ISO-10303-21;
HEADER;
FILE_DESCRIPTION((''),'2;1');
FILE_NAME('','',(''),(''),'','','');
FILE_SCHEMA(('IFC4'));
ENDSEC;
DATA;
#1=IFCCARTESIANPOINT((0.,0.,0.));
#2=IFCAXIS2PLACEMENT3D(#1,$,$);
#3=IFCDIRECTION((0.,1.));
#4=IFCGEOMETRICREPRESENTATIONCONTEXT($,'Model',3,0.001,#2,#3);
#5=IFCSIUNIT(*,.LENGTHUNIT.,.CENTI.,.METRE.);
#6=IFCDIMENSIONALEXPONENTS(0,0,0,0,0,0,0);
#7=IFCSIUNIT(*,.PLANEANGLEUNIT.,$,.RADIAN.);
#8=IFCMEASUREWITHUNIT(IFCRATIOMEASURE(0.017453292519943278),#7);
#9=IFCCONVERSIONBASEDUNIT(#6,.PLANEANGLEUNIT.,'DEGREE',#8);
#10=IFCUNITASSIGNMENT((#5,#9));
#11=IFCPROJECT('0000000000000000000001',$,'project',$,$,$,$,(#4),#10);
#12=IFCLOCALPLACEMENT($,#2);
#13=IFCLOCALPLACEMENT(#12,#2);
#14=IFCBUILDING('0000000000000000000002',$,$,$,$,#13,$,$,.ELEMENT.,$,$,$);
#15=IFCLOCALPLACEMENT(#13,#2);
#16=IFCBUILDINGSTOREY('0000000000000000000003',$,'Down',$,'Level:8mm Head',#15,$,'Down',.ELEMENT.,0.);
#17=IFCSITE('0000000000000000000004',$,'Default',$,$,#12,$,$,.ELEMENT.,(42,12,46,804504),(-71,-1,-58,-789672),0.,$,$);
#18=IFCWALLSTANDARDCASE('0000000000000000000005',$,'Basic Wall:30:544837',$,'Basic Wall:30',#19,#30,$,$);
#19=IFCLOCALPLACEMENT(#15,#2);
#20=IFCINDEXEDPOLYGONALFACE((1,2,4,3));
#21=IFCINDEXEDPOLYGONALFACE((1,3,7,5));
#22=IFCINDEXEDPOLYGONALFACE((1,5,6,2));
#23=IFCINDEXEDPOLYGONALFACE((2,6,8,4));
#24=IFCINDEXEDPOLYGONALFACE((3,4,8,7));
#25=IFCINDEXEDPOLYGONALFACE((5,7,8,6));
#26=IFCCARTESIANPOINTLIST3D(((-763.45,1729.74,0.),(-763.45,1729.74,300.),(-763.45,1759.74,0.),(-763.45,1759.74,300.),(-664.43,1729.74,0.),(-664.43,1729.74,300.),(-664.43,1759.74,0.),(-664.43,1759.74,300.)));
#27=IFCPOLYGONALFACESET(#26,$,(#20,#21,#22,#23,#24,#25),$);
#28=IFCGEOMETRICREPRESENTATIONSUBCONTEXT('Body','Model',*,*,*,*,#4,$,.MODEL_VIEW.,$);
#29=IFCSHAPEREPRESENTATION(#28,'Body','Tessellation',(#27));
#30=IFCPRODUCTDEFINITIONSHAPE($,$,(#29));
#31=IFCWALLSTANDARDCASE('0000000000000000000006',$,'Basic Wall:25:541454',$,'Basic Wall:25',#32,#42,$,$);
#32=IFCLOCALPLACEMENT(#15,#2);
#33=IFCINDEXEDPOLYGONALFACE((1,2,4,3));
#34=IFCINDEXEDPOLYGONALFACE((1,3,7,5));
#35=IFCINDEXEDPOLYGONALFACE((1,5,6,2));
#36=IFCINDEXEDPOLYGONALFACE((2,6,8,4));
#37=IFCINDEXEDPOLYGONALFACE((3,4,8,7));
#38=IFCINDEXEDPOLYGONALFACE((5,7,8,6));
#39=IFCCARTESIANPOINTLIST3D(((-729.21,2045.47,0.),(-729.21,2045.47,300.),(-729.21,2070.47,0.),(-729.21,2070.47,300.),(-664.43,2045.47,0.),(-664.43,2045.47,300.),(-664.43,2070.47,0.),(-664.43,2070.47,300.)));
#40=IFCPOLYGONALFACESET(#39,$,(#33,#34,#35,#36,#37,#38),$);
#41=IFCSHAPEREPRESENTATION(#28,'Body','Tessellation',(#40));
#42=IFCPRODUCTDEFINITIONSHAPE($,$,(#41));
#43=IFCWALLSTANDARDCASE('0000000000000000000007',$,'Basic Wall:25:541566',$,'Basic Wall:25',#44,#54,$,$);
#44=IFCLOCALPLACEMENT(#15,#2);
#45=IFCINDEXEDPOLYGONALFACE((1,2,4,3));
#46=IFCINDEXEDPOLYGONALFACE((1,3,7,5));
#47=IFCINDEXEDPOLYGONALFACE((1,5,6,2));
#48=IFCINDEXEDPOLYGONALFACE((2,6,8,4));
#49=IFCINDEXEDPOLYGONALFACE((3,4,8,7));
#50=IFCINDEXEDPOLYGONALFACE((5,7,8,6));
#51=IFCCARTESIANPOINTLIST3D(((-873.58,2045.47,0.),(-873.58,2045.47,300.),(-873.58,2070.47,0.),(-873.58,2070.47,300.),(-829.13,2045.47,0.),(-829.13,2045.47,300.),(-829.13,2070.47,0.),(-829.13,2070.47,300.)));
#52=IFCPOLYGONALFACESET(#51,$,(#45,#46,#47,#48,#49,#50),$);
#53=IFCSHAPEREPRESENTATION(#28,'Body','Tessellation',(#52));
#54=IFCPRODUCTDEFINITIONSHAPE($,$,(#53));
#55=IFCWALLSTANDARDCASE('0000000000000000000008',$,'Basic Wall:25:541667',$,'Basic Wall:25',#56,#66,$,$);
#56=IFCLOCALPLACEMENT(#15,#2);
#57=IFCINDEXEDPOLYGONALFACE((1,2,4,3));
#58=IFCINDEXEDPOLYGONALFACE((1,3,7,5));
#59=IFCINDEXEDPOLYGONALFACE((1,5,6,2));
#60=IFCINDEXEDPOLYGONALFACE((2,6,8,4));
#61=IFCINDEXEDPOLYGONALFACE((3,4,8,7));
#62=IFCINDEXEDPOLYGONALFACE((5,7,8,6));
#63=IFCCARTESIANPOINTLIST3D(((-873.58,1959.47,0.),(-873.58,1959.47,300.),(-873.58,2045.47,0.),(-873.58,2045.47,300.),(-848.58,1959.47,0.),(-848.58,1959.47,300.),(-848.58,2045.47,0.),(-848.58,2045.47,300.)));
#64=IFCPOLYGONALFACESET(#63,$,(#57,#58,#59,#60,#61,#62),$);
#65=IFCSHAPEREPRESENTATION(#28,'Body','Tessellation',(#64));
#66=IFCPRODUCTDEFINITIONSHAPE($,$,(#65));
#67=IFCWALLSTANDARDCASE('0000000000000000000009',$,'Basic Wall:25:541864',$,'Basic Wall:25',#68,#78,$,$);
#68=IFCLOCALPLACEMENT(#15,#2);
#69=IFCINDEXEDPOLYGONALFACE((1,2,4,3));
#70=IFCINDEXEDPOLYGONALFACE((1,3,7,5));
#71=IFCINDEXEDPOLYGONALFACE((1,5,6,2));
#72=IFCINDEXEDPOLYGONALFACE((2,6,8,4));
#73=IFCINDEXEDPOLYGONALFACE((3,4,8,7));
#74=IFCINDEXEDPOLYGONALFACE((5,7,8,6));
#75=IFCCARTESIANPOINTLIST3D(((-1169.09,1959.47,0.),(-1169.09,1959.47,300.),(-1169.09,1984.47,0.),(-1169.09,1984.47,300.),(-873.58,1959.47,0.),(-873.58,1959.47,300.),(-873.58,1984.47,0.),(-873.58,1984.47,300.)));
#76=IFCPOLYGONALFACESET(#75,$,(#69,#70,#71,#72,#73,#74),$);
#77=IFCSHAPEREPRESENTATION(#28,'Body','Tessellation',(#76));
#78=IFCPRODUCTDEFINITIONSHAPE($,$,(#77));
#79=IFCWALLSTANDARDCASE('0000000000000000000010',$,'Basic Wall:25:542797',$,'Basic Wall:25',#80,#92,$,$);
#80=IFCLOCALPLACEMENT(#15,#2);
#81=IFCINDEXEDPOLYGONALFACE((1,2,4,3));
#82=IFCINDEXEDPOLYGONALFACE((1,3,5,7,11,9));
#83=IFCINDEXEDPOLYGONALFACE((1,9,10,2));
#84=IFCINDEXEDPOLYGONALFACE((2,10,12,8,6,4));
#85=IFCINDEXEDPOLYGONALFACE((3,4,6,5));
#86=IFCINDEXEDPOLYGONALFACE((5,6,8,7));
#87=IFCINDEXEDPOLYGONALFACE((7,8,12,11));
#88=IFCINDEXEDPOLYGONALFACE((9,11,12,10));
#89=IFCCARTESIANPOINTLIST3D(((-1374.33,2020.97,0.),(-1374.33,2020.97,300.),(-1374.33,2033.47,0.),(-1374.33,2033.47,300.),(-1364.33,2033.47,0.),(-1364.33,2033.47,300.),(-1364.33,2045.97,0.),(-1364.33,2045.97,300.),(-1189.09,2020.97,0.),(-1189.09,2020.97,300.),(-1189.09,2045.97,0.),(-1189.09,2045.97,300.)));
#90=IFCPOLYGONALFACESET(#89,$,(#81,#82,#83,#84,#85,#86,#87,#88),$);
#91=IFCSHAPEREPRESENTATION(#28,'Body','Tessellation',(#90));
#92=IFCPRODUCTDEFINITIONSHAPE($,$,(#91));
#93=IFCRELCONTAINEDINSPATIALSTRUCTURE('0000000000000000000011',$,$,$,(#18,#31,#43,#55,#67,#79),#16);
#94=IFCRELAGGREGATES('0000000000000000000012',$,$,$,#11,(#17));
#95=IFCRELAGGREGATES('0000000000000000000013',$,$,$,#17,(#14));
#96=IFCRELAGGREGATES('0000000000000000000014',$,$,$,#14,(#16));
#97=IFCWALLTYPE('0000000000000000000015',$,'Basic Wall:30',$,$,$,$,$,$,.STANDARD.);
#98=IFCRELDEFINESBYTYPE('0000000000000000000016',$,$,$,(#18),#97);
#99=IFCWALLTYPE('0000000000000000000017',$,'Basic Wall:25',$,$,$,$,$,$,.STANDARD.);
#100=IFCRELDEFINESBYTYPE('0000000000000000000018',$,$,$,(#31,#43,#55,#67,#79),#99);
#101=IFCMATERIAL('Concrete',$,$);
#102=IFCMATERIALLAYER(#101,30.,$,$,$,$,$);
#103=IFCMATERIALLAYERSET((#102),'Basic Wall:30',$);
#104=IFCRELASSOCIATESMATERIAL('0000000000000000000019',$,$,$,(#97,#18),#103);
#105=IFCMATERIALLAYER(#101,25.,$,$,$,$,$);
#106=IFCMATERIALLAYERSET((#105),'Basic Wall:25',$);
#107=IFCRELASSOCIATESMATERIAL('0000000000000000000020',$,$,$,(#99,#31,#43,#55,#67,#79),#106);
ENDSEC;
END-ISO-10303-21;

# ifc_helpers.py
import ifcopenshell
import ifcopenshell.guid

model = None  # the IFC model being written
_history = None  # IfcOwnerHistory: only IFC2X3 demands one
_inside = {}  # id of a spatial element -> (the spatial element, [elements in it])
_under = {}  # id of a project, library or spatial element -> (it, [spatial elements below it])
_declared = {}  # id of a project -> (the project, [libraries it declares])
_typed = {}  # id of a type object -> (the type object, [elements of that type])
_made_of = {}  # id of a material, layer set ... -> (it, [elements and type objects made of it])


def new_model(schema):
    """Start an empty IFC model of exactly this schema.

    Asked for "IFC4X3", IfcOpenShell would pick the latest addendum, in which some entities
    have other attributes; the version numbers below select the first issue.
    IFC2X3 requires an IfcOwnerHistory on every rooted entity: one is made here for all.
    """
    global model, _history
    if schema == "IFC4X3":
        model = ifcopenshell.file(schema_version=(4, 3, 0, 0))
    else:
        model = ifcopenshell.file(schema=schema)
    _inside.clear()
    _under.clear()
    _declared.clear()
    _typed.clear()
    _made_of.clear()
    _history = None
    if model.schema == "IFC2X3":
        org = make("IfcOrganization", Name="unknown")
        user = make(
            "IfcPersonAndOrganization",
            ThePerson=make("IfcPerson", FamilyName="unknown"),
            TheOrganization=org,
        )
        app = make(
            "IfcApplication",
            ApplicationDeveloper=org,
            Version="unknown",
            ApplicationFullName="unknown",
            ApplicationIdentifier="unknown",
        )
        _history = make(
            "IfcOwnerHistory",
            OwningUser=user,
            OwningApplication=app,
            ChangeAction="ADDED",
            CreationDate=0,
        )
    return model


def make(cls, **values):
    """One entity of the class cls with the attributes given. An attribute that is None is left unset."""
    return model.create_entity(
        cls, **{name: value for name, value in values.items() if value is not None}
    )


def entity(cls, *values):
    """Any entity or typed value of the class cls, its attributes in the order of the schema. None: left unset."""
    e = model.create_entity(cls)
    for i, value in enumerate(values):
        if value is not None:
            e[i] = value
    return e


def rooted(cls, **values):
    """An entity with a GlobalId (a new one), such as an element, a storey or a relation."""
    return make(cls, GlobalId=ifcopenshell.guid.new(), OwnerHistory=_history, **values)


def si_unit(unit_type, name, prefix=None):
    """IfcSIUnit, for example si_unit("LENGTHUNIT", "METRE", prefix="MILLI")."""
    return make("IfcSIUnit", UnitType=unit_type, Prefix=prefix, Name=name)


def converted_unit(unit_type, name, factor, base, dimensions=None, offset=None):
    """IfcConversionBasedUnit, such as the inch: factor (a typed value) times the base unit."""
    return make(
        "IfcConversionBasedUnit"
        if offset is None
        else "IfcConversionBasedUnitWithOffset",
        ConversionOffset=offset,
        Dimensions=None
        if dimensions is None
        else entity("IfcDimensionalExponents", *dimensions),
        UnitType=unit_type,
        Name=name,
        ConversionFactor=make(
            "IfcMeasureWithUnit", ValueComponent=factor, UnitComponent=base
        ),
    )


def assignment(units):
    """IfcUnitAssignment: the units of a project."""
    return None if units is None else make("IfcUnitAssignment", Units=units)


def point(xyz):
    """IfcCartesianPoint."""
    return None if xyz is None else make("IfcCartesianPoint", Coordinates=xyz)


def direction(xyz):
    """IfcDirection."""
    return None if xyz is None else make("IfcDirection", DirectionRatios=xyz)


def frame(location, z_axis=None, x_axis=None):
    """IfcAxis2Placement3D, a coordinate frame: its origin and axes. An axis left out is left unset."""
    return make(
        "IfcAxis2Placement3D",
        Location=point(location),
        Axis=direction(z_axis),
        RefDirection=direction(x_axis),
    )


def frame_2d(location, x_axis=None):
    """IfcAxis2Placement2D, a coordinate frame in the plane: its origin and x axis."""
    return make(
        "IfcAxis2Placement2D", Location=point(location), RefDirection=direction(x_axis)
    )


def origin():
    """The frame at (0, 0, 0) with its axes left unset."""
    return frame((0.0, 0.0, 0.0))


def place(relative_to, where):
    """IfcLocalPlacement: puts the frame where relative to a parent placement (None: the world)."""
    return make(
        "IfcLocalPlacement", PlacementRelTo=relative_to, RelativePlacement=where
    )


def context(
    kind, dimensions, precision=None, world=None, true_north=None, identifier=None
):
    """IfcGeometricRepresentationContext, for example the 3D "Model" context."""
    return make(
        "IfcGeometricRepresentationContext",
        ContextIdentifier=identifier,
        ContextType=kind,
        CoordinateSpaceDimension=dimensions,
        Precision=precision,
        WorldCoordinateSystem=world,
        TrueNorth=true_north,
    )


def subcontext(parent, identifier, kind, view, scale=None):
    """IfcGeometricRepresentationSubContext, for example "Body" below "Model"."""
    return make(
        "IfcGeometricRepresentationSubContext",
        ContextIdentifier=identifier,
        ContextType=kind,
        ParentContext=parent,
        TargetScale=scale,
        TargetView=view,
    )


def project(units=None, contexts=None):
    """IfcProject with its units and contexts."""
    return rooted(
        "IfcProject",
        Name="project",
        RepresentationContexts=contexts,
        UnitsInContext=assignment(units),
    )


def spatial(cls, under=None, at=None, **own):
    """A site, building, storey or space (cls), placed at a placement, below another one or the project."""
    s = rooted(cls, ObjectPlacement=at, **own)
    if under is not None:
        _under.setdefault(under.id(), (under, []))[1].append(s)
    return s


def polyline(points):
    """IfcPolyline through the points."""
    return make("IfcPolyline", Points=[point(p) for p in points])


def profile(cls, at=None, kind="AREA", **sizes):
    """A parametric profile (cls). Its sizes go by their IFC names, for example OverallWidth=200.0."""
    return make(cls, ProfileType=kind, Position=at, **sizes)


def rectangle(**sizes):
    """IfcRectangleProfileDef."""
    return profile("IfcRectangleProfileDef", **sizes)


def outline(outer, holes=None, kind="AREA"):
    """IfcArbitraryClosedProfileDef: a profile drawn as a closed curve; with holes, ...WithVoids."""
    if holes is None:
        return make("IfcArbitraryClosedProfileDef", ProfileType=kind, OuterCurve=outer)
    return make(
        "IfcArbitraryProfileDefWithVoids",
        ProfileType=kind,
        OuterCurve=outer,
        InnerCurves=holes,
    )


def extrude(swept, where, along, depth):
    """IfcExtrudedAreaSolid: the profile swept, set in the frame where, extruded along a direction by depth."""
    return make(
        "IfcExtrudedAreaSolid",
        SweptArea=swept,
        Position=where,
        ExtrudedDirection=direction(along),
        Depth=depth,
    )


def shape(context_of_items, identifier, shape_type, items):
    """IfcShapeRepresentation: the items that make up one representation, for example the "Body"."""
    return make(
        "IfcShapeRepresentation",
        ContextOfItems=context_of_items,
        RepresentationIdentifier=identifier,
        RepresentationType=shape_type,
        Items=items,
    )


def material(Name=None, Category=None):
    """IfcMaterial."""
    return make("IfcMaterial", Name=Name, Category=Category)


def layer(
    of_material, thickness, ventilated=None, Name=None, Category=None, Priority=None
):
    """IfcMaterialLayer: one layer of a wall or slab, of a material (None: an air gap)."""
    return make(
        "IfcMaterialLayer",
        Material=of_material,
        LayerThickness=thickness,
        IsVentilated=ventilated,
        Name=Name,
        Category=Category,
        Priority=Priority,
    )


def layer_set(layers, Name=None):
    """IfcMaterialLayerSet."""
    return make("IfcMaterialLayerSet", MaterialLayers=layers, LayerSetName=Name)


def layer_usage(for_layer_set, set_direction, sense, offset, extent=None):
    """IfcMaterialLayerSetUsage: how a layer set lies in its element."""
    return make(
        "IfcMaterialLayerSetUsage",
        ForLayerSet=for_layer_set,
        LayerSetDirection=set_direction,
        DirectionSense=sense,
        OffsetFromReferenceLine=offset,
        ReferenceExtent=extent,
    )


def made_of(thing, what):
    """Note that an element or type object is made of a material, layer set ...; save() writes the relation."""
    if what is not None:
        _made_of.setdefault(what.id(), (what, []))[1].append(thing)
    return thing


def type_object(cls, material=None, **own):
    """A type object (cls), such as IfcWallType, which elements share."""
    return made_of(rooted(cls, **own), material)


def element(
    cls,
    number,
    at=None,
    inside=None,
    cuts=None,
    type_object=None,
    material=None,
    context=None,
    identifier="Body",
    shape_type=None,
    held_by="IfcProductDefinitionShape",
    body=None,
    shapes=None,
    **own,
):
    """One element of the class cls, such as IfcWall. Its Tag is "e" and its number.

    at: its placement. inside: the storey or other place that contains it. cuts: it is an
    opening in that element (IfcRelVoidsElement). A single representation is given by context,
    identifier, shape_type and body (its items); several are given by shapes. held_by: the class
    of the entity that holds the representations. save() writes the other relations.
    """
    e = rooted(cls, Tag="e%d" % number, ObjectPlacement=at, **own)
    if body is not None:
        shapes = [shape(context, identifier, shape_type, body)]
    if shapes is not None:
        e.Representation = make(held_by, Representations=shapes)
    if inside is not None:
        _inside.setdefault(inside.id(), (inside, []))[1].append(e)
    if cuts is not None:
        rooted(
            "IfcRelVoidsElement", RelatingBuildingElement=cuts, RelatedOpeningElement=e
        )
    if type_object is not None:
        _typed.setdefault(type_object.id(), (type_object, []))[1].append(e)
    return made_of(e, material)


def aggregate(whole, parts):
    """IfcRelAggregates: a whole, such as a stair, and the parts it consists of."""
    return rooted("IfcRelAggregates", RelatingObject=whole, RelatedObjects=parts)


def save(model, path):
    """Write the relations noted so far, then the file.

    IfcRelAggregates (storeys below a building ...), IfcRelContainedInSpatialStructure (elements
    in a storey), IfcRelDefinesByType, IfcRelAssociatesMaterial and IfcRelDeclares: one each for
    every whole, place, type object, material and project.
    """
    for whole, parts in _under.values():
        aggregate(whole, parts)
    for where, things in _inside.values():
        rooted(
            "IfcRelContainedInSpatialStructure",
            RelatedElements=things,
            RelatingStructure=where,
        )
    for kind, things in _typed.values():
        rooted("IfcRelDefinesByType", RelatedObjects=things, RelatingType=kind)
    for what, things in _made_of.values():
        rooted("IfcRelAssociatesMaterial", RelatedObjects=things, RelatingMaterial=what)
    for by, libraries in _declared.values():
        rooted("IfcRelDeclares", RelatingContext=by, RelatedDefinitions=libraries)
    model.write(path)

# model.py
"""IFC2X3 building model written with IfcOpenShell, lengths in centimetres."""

from ifc_helpers import new_model, entity, si_unit, converted_unit, direction, frame, frame_2d, origin, place, context, subcontext, project, spatial, polyline, rectangle, outline, extrude, material, layer, layer_set, layer_usage, type_object, element, save


model = new_model("IFC2X3")

# Units and contexts
model_context = context("Model", 3, precision=0.001, world=origin(), true_north=direction((0.0, 1.0)))
body_context = subcontext(model_context, "Body", "Model", "MODEL_VIEW")
ifc_project = project(units=[si_unit("LENGTHUNIT", "METRE", prefix="CENTI"), converted_unit("PLANEANGLEUNIT", "DEGREE", entity("IfcRatioMeasure", 0.017453292519943278), si_unit("PLANEANGLEUNIT", "RADIAN"), dimensions=[0, 0, 0, 0, 0, 0, 0])], contexts=[model_context])

# Site, building, storey
site_placement = place(None, origin())
site = spatial("IfcSite", under=ifc_project, at=site_placement, Name="Default", CompositionType="ELEMENT", RefLatitude=(42, 12, 46, 804504), RefLongitude=(-71, -1, -58, -789672), RefElevation=0.0)
building_placement = place(site_placement, origin())
building = spatial("IfcBuilding", under=site, at=building_placement, CompositionType="ELEMENT")
storey_placement = place(building_placement, origin())
storey = spatial("IfcBuildingStorey", under=building, at=storey_placement, Name="Down", ObjectType="Level:8mm Head", LongName="Down", CompositionType="ELEMENT", Elevation=0.0)

# Shared definitions
ifc_material = material(Name="Concrete")

# Walls
ifc_layer_1 = layer(ifc_material, 30.0)
ifc_layer_set_1 = layer_set([ifc_layer_1], Name="Basic Wall:30")
wall_type_1 = type_object("IfcWallType", Name="Basic Wall:30", PredefinedType="STANDARD", material=ifc_layer_set_1)
ifc_layer_usage_1 = layer_usage(ifc_layer_set_1, "AXIS2", "POSITIVE", -15.0)
wall_1_placement = place(storey_placement, frame((-763.45, 1744.74, 0.0)))
element("IfcWallStandardCase", 1, at=wall_1_placement, inside=storey, type_object=wall_type_1, material=ifc_layer_usage_1, Name="Basic Wall:30:544837", ObjectType="Basic Wall:30", context=body_context, shape_type="SweptSolid", body=[
    extrude(rectangle(XDim=99.01, YDim=30.0, at=frame_2d((49.51, 0.0), x_axis=(-1.0, 0.0))), origin(), (0.0, 0.0, 1.0), 300.0),
])
ifc_layer_2 = layer(ifc_material, 25.0)
ifc_layer_set_2 = layer_set([ifc_layer_2], Name="Basic Wall:25")
ifc_layer_usage_2 = layer_usage(ifc_layer_set_2, "AXIS2", "NEGATIVE", 12.5)
wall_type_2 = type_object("IfcWallType", Name="Basic Wall:25", PredefinedType="STANDARD", material=ifc_layer_set_2)
wall_2_placement = place(storey_placement, frame((-664.43, 2057.97, 0.0), z_axis=(0.0, 0.0, 1.0), x_axis=(-1.0, 0.0, 0.0)))
element("IfcWallStandardCase", 2, at=wall_2_placement, inside=storey, type_object=wall_type_2, material=ifc_layer_usage_2, Name="Basic Wall:25:541454", ObjectType="Basic Wall:25", context=body_context, shape_type="SweptSolid", body=[
    extrude(rectangle(XDim=64.78, YDim=25.0, at=frame_2d((32.39, 0.0), x_axis=(-1.0, 0.0))), origin(), (0.0, 0.0, 1.0), 300.0),
])
ifc_layer_usage_3 = layer_usage(ifc_layer_set_2, "AXIS2", "NEGATIVE", 12.5)
wall_3_placement = place(storey_placement, frame((-829.13, 2057.97, 0.0), z_axis=(0.0, 0.0, 1.0), x_axis=(-1.0, 0.0, 0.0)))
element("IfcWallStandardCase", 3, at=wall_3_placement, inside=storey, type_object=wall_type_2, material=ifc_layer_usage_3, Name="Basic Wall:25:541566", ObjectType="Basic Wall:25", context=body_context, shape_type="SweptSolid", body=[
    extrude(rectangle(XDim=44.45, YDim=25.0, at=frame_2d((22.23, 0.0), x_axis=(-1.0, 0.0))), origin(), (0.0, 0.0, 1.0), 300.0),
])
ifc_layer_usage_4 = layer_usage(ifc_layer_set_2, "AXIS2", "POSITIVE", -12.5)
wall_4_placement = place(storey_placement, frame((-861.08, 2045.47, 0.0), z_axis=(0.0, 0.0, 1.0), x_axis=(0.0, -1.0, 0.0)))
element("IfcWallStandardCase", 4, at=wall_4_placement, inside=storey, type_object=wall_type_2, material=ifc_layer_usage_4, Name="Basic Wall:25:541667", ObjectType="Basic Wall:25", context=body_context, shape_type="SweptSolid", body=[
    extrude(rectangle(XDim=86.0, YDim=25.0, at=frame_2d((43.0, 0.0), x_axis=(-1.0, 0.0))), origin(), (0.0, 0.0, 1.0), 300.0),
])
ifc_layer_usage_5 = layer_usage(ifc_layer_set_2, "AXIS2", "NEGATIVE", 12.5)
wall_5_placement = place(storey_placement, frame((-873.58, 1971.97, 0.0), z_axis=(0.0, 0.0, 1.0), x_axis=(-1.0, 0.0, 0.0)))
element("IfcWallStandardCase", 5, at=wall_5_placement, inside=storey, type_object=wall_type_2, material=ifc_layer_usage_5, Name="Basic Wall:25:541864", ObjectType="Basic Wall:25", context=body_context, shape_type="SweptSolid", body=[
    extrude(rectangle(XDim=295.51, YDim=25.0, at=frame_2d((147.76, 0.0), x_axis=(-1.0, 0.0))), origin(), (0.0, 0.0, 1.0), 300.0),
])
ifc_layer_usage_6 = layer_usage(ifc_layer_set_2, "AXIS2", "POSITIVE", -12.5)
wall_6_placement = place(storey_placement, frame((-1189.09, 2033.47, 0.0), z_axis=(0.0, 0.0, 1.0), x_axis=(-1.0, 0.0, 0.0)))
element("IfcWallStandardCase", 6, at=wall_6_placement, inside=storey, type_object=wall_type_2, material=ifc_layer_usage_6, Name="Basic Wall:25:542797", ObjectType="Basic Wall:25", context=body_context, shape_type="SweptSolid", body=[
    extrude(outline(polyline([(175.23, -12.5), (175.23, 0.0), (185.23, 0.0), (185.23, 12.5), (0.0, 12.5), (0.0, -12.5), (175.23, -12.5)])), origin(), (0.0, 0.0, 1.0), 300.0),
])

save(model, "model.ifc")
